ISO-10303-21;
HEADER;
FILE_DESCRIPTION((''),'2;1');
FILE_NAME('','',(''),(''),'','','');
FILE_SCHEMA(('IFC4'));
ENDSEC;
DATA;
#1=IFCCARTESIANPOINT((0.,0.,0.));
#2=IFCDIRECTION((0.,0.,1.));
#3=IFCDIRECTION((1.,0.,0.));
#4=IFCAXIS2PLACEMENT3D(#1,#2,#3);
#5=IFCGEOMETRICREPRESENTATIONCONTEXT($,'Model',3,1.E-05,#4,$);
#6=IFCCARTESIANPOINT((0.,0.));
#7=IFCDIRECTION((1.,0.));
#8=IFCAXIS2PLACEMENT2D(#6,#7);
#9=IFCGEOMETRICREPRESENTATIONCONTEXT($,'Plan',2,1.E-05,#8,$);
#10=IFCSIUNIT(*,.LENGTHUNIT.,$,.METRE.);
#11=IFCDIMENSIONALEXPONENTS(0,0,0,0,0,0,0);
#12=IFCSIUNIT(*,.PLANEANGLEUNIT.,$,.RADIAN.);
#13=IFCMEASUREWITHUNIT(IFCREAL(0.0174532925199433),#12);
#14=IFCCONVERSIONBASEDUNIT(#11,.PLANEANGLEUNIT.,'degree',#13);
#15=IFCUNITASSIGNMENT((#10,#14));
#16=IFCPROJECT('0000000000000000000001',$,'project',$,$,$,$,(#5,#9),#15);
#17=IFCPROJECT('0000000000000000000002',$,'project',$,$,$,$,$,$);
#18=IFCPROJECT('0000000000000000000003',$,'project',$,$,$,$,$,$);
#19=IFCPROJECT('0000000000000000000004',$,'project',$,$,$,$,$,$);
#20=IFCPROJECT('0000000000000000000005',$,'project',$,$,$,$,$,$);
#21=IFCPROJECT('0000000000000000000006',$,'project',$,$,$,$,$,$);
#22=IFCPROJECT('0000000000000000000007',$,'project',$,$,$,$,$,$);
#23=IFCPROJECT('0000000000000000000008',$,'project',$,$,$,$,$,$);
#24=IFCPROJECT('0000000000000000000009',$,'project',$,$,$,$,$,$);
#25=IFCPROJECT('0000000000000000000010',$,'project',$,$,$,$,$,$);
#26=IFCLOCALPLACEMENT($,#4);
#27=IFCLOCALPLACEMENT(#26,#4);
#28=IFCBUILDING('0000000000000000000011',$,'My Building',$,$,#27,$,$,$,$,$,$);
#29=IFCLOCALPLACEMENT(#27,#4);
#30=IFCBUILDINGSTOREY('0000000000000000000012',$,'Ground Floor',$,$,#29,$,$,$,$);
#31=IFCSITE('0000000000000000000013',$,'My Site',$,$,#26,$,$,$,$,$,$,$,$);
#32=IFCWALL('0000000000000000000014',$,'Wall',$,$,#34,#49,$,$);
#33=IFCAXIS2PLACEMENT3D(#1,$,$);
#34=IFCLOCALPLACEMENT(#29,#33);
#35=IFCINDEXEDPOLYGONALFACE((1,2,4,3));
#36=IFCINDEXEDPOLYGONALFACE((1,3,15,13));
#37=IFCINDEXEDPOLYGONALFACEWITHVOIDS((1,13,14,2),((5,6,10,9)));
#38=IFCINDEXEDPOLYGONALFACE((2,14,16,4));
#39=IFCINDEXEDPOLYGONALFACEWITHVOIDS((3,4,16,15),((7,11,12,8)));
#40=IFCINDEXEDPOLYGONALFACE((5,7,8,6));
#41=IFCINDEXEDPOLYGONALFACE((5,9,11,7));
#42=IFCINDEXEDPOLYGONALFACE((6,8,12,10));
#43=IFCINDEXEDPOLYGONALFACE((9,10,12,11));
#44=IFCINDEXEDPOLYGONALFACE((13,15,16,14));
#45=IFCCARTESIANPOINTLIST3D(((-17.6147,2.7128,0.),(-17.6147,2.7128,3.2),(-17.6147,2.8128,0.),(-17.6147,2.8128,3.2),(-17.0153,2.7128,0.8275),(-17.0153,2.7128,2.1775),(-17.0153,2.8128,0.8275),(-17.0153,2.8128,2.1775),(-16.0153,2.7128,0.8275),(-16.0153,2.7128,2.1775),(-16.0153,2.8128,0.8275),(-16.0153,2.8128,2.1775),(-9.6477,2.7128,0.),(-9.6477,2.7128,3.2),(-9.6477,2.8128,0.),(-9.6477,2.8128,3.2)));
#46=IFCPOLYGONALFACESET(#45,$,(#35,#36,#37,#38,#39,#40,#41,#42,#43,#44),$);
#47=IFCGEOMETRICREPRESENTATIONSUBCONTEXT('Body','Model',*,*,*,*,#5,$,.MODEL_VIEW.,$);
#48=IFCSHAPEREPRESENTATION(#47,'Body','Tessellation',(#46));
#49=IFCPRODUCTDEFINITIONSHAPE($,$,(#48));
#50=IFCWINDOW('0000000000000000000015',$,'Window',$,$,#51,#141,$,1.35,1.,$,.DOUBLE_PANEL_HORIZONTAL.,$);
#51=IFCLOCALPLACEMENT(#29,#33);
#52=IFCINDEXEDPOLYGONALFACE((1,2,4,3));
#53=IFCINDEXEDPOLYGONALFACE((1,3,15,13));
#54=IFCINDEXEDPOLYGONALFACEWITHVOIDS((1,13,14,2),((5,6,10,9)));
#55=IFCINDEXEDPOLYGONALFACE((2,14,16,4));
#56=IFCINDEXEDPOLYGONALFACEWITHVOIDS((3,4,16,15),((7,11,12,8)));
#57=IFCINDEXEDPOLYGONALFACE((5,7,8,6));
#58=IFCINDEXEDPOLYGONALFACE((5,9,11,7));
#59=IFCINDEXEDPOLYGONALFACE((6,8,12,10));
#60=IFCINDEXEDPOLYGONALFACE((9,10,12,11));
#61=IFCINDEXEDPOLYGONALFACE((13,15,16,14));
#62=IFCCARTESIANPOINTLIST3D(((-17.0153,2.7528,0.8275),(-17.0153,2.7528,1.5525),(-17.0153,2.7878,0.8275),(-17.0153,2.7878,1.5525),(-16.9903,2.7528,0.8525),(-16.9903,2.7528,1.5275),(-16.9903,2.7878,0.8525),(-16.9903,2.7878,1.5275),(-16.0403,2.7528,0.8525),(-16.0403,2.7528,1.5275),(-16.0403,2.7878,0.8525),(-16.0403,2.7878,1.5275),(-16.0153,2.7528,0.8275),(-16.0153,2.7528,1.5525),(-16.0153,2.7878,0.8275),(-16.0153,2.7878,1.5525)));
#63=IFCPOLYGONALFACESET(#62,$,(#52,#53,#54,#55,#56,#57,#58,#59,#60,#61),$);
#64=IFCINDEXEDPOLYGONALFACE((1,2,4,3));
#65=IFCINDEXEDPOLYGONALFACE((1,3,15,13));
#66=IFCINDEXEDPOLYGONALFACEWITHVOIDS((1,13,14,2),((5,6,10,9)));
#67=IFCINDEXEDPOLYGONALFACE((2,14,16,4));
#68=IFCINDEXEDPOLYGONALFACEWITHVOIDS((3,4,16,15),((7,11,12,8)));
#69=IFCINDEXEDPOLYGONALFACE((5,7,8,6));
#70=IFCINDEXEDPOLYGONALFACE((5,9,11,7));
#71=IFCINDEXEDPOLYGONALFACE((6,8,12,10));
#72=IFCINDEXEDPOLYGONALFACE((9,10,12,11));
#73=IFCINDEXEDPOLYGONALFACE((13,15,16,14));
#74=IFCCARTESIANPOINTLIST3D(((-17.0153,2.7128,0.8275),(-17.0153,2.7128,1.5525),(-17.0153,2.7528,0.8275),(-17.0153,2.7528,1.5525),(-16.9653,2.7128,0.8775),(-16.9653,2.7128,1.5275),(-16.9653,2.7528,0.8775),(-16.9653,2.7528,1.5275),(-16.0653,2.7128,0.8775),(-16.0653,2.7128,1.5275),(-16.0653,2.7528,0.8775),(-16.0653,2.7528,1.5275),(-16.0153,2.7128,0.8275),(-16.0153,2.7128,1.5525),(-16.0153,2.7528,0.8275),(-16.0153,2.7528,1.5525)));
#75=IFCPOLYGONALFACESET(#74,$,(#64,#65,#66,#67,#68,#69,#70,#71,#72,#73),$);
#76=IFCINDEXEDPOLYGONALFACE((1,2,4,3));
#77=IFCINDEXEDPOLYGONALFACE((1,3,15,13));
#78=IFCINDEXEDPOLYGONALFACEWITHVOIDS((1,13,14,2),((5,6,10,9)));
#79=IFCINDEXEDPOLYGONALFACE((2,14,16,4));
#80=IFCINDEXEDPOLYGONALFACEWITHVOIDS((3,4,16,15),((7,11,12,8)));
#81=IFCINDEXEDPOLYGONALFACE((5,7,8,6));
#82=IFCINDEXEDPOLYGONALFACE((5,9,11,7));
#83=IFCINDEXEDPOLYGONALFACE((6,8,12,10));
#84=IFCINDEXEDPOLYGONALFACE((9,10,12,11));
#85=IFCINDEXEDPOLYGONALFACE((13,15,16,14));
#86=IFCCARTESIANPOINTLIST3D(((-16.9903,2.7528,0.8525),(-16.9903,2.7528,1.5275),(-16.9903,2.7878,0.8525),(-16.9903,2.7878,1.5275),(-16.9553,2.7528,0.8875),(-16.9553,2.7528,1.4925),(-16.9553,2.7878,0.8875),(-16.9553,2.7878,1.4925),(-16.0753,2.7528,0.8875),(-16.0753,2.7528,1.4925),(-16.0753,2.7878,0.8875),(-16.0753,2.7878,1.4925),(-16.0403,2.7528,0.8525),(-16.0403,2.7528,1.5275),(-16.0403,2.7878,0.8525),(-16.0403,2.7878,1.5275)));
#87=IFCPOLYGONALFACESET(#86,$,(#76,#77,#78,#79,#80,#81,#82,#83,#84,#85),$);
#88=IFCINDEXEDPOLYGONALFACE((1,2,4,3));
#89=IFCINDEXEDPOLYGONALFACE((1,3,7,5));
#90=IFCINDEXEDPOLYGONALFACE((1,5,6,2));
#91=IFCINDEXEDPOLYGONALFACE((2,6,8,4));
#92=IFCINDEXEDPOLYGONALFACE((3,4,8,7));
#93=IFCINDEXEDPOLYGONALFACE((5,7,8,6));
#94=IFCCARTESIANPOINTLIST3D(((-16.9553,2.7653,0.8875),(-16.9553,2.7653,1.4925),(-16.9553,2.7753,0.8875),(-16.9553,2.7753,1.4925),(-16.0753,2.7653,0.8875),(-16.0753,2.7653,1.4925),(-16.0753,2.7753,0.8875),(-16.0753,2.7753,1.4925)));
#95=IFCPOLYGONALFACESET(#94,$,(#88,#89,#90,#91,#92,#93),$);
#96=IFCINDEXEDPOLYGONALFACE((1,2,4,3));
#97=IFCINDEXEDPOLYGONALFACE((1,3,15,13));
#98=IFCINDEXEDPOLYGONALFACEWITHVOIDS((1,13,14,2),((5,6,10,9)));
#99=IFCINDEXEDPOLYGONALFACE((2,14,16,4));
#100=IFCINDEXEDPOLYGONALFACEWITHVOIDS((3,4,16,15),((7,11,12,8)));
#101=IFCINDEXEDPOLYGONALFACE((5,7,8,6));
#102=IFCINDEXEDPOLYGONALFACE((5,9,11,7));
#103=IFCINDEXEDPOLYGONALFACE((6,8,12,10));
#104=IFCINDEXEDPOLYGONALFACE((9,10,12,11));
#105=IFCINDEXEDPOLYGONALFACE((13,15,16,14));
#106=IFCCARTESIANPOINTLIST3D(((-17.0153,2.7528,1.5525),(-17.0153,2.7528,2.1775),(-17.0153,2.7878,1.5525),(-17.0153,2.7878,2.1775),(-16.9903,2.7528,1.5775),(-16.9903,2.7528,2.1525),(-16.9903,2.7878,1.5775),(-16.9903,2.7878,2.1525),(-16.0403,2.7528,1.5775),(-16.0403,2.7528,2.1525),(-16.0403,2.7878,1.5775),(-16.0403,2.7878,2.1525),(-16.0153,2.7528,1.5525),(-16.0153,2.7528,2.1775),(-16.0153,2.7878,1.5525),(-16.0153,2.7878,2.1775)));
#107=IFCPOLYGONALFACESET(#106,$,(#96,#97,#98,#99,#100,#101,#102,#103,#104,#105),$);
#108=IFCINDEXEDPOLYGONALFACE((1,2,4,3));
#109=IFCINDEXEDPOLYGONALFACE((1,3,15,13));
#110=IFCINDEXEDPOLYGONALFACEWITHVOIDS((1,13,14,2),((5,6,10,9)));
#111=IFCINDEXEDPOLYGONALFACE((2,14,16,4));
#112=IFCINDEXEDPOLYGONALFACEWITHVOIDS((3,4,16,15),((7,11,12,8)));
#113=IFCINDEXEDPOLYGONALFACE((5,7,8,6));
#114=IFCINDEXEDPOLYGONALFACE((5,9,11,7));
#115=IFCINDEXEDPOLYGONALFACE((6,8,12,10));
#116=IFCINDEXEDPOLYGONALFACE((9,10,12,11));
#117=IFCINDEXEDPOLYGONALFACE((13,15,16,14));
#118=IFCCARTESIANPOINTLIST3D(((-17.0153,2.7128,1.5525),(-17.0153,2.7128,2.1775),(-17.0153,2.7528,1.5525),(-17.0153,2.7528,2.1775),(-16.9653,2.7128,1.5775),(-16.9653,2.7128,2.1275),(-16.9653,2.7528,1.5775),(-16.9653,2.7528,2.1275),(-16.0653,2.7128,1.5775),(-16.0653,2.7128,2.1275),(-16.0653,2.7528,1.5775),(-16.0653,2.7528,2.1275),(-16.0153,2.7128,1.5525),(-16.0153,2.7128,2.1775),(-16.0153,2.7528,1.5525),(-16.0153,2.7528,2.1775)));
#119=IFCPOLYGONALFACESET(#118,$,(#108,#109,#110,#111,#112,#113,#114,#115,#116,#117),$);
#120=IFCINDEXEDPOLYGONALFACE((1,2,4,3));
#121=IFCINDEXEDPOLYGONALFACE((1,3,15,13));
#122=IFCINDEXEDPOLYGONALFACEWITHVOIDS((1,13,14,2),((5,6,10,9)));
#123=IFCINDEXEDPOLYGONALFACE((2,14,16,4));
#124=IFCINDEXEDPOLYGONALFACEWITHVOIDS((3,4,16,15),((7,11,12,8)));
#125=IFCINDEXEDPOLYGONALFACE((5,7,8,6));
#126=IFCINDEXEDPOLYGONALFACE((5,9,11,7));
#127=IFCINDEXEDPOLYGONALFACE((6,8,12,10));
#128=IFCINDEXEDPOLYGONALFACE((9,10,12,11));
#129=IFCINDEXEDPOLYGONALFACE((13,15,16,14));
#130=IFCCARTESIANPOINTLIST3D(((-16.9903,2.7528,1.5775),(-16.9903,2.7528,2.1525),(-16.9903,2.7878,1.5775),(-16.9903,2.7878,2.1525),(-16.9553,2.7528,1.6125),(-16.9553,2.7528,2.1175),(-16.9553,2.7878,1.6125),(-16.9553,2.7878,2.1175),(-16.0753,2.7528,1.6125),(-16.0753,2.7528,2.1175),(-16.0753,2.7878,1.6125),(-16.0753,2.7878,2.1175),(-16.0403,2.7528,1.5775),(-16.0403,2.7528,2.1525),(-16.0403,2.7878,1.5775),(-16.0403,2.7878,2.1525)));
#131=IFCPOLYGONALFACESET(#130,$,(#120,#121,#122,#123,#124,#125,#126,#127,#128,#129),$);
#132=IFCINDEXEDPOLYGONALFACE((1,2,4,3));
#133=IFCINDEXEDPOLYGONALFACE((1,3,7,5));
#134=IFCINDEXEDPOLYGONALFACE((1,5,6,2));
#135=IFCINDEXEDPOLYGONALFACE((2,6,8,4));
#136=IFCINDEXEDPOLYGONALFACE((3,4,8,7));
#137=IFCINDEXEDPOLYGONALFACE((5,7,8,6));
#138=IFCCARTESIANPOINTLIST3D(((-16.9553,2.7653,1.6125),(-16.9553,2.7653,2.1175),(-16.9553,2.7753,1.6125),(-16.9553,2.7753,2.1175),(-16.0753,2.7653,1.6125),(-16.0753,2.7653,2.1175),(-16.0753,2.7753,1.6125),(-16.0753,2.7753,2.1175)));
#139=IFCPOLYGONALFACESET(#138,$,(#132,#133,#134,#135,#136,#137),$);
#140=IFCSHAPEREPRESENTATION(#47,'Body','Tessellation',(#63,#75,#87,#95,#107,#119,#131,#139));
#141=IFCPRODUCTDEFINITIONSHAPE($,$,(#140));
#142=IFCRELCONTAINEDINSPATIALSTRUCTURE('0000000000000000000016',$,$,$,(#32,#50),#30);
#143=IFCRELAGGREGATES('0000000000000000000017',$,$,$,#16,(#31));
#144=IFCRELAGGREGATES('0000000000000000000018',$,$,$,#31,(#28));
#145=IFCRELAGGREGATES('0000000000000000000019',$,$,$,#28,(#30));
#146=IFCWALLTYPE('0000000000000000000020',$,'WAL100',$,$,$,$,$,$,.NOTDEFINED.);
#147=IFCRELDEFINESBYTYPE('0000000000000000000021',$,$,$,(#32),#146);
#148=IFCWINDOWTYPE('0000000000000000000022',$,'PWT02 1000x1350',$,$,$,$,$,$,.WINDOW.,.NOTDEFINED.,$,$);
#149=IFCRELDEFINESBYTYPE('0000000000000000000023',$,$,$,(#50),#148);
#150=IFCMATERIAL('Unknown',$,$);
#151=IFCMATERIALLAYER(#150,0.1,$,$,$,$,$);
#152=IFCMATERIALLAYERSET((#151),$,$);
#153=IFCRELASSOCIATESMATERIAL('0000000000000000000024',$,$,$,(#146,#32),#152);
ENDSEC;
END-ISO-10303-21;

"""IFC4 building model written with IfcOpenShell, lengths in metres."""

from ifc_helpers import new_model, entity, si_unit, converted_unit, frame, origin_with_axes, origin_2d_with_axis, place, context, subcontext, project, spatial, line, indexed_curve, outline, extrude, shape, source, transform, mapped, material, layer, layer_set, layer_usage, type_object, type_shapes, element, fill, save


model = new_model("IFC4")

# Units and contexts
model_context = context("Model", 3, precision=1e-05, world=origin_with_axes())
plan_context = context("Plan", 2, precision=1e-05, world=origin_2d_with_axis())
body_context_1 = subcontext(model_context, "Body", "Model", "MODEL_VIEW")
body_context_2 = subcontext(plan_context, "Body", "Plan", "PLAN_VIEW")
ifc_project_1 = project(units=[si_unit("LENGTHUNIT", "METRE"), converted_unit("PLANEANGLEUNIT", "degree", entity("IfcReal", 0.0174532925199433), si_unit("PLANEANGLEUNIT", "RADIAN"), dimensions=[0, 0, 0, 0, 0, 0, 0])], contexts=[model_context, plan_context])
ifc_project_2 = project()
ifc_project_3 = project()
ifc_project_4 = project()
ifc_project_5 = project()
ifc_project_6 = project()
ifc_project_7 = project()
ifc_project_8 = project()
ifc_project_9 = project()
ifc_project_10 = project()

# Site, building, storey
site_placement = place(None, origin_with_axes())
site = spatial("IfcSite", under=ifc_project_1, at=site_placement, Name="My Site")
building_placement = place(site_placement, origin_with_axes())
building = spatial("IfcBuilding", under=site, at=building_placement, Name="My Building")
storey_placement = place(building_placement, origin_with_axes())
storey = spatial("IfcBuildingStorey", under=building, at=storey_placement, Name="Ground Floor")

# Shared definitions
ifc_material = material(Name="Unknown")

# Shared definitions
ifc_layer_1 = layer(ifc_material, 0.1)
ifc_layer_set_1 = layer_set([ifc_layer_1])
wall_type = type_object("IfcWallType", Name="WAL100", PredefinedType="NOTDEFINED", material=ifc_layer_set_1)

# Wall, opening, window
ifc_layer_usage_1 = layer_usage(ifc_layer_set_1, "AXIS2", "POSITIVE", 0.0)
wall_1_placement = place(storey_placement, frame((-17.6147, 2.7128, 0.0), z_axis=(0.0, 0.0, 1.0), x_axis=(1.0, 0.0, 0.0)))
wall_1 = element("IfcWall", 1, at=wall_1_placement, inside=storey, type_object=wall_type, material=ifc_layer_usage_1, Name="Wall", context=body_context_1, shape_type="SweptSolid", body=[
    extrude(outline(indexed_curve([(0.0, 0.0), (0.0, 0.1), (7.967, 0.1), (7.967, 0.0), (0.0, 0.0)], self_intersect=False)), origin_with_axes(), (0.0, 0.0, 1.0), 3.2),
])
shared_shape_1 = source(origin_with_axes(), body_context_1, "Body", "SweptSolid", [
    extrude(outline(indexed_curve([(0.0, 0.0), (1.0, 0.0), (1.0, 1.35), (0.0, 1.35)], segments=[line(1, 2, 2, 3, 3, 4, 4, 1)])), frame((0.0, -0.1, 0.0), z_axis=(0.0, -1.0, 0.0), x_axis=(1.0, 0.0, 0.0)), (0.0, 0.0, -1.0), 0.3),
])
opening_1_placement = place(wall_1_placement, frame((0.5995, 0.0, 0.8275), z_axis=(0.0, 0.0, 1.0), x_axis=(1.0, 0.0, 0.0)))
opening_1 = element("IfcOpeningElement", 2, at=opening_1_placement, cuts=wall_1, PredefinedType="OPENING", context=body_context_1, shape_type="MappedRepresentation", body=[
    mapped(shared_shape_1, transform((0.0, 0.0, 0.0), x_axis=(1.0, 0.0, 0.0), y_axis=(0.0, 1.0, 0.0), z_axis=(0.0, 0.0, 1.0), scale=1.0)),
])
window_type_1 = type_object("IfcWindowType", Name="PWT02 1000x1350", PartitioningType="NOTDEFINED", PredefinedType="WINDOW")
shared_shape_2 = source(origin_with_axes(), body_context_1, "Body", "SweptSolid", [
    extrude(outline(indexed_curve([(0.0, 0.0), (1.0, 0.0), (1.0, 0.725), (0.0, 0.725)], segments=[line(1, 2, 2, 3, 3, 4, 4, 1)]), holes=[indexed_curve([(0.025, 0.025), (0.975, 0.025), (0.975, 0.7), (0.025, 0.7)], segments=[line(1, 2, 2, 3, 3, 4, 4, 1)])]), frame((0.0, 0.04, 0.0), z_axis=(0.0, -1.0, 0.0), x_axis=(1.0, 0.0, 0.0)), (0.0, 0.0, -1.0), 0.035),
    extrude(outline(indexed_curve([(0.0, 0.0), (1.0, 0.0), (1.0, 0.725), (0.0, 0.725)], segments=[line(1, 2, 2, 3, 3, 4, 4, 1)]), holes=[indexed_curve([(0.05, 0.05), (0.95, 0.05), (0.95, 0.7), (0.05, 0.7)], segments=[line(1, 2, 2, 3, 3, 4, 4, 1)])]), frame((0.0, 0.0, 0.0), z_axis=(0.0, -1.0, 0.0), x_axis=(1.0, 0.0, 0.0)), (0.0, 0.0, -1.0), 0.04),
    extrude(outline(indexed_curve([(0.0, 0.0), (0.95, 0.0), (0.95, 0.675), (0.0, 0.675)], segments=[line(1, 2, 2, 3, 3, 4, 4, 1)]), holes=[indexed_curve([(0.035, 0.035), (0.915, 0.035), (0.915, 0.64), (0.035, 0.64)], segments=[line(1, 2, 2, 3, 3, 4, 4, 1)])]), frame((0.025, 0.04, 0.025), z_axis=(0.0, -1.0, 0.0), x_axis=(1.0, 0.0, 0.0)), (0.0, 0.0, -1.0), 0.035),
    extrude(outline(indexed_curve([(0.035, 0.035), (0.915, 0.035), (0.915, 0.64), (0.035, 0.64)], segments=[line(1, 2, 2, 3, 3, 4, 4, 1)])), frame((0.025, 0.0525, 0.025), z_axis=(0.0, -1.0, 0.0), x_axis=(1.0, 0.0, 0.0)), (0.0, 0.0, -1.0), 0.01),
    extrude(outline(indexed_curve([(0.0, 0.0), (1.0, 0.0), (1.0, 0.625), (0.0, 0.625)], segments=[line(1, 2, 2, 3, 3, 4, 4, 1)]), holes=[indexed_curve([(0.025, 0.025), (0.975, 0.025), (0.975, 0.6), (0.025, 0.6)], segments=[line(1, 2, 2, 3, 3, 4, 4, 1)])]), frame((0.0, 0.04, 0.725), z_axis=(0.0, -1.0, 0.0), x_axis=(1.0, 0.0, 0.0)), (0.0, 0.0, -1.0), 0.035),
    extrude(outline(indexed_curve([(0.0, 0.0), (1.0, 0.0), (1.0, 0.625), (0.0, 0.625)], segments=[line(1, 2, 2, 3, 3, 4, 4, 1)]), holes=[indexed_curve([(0.05, 0.025), (0.95, 0.025), (0.95, 0.575), (0.05, 0.575)], segments=[line(1, 2, 2, 3, 3, 4, 4, 1)])]), frame((0.0, 0.0, 0.725), z_axis=(0.0, -1.0, 0.0), x_axis=(1.0, 0.0, 0.0)), (0.0, 0.0, -1.0), 0.04),
    extrude(outline(indexed_curve([(0.0, 0.0), (0.95, 0.0), (0.95, 0.575), (0.0, 0.575)], segments=[line(1, 2, 2, 3, 3, 4, 4, 1)]), holes=[indexed_curve([(0.035, 0.035), (0.915, 0.035), (0.915, 0.54), (0.035, 0.54)], segments=[line(1, 2, 2, 3, 3, 4, 4, 1)])]), frame((0.025, 0.04, 0.75), z_axis=(0.0, -1.0, 0.0), x_axis=(1.0, 0.0, 0.0)), (0.0, 0.0, -1.0), 0.035),
    extrude(outline(indexed_curve([(0.035, 0.035), (0.915, 0.035), (0.915, 0.54), (0.035, 0.54)], segments=[line(1, 2, 2, 3, 3, 4, 4, 1)])), frame((0.025, 0.0525, 0.75), z_axis=(0.0, -1.0, 0.0), x_axis=(1.0, 0.0, 0.0)), (0.0, 0.0, -1.0), 0.01),
])
shared_shape_3 = source(origin_with_axes(), body_context_2, "Body", "Curve2D", [
    entity("IfcIndexedPolyCurve", entity("IfcCartesianPointList2D", [[0.05, 0.0], [0.95, 0.0]]), [entity("IfcLineIndex", [1, 2])]),
    entity("IfcIndexedPolyCurve", entity("IfcCartesianPointList2D", [[0.0, 0.075], [0.025, 0.075], [0.025, 0.04], [0.05, 0.04], [0.05, 0.0], [0.0, 0.0]]), [entity("IfcLineIndex", [1, 2, 2, 3, 3, 4, 4, 5, 5, 6, 6, 1])]),
    entity("IfcIndexedPolyCurve", entity("IfcCartesianPointList2D", [[1.0, 0.075], [0.975, 0.075], [0.975, 0.04], [0.95, 0.04], [0.95, 0.0], [1.0, 0.0]]), [entity("IfcLineIndex", [1, 2, 2, 3, 3, 4, 4, 5, 5, 6, 6, 1])]),
    entity("IfcIndexedPolyCurve", entity("IfcCartesianPointList2D", [[0.025, 0.04], [0.06, 0.04], [0.06, 0.075], [0.025, 0.075]]), [entity("IfcLineIndex", [1, 2, 2, 3, 3, 4, 4, 1])]),
    entity("IfcIndexedPolyCurve", entity("IfcCartesianPointList2D", [[0.975, 0.04], [0.94, 0.04], [0.94, 0.075], [0.975, 0.075]]), [entity("IfcLineIndex", [1, 2, 2, 3, 3, 4, 4, 1])]),
    entity("IfcIndexedPolyCurve", entity("IfcCartesianPointList2D", [[0.06, 0.04], [0.94, 0.04]]), [entity("IfcLineIndex", [1, 2])]),
    entity("IfcIndexedPolyCurve", entity("IfcCartesianPointList2D", [[0.06, 0.075], [0.94, 0.075]]), [entity("IfcLineIndex", [1, 2])]),
    entity("IfcIndexedPolyCurve", entity("IfcCartesianPointList2D", [[0.06, 0.0575], [0.94, 0.0575]]), [entity("IfcLineIndex", [1, 2])]),
])
type_shapes(window_type_1, [shared_shape_2, shared_shape_3])
window_1_placement = place(opening_1_placement, origin_with_axes())
window_1 = element("IfcWindow", 3, at=window_1_placement, inside=storey, type_object=window_type_1, Name="Window", OverallHeight=1.35, OverallWidth=1.0, PartitioningType="DOUBLE_PANEL_HORIZONTAL", shapes=[
    shape(body_context_1, "Body", "MappedRepresentation", [mapped(shared_shape_2, transform((0.0, 0.0, 0.0), x_axis=(1.0, 0.0, 0.0), y_axis=(0.0, 1.0, 0.0), z_axis=(0.0, 0.0, 1.0), scale=1.0))]),
    shape(body_context_2, "Body", "MappedRepresentation", [mapped(shared_shape_3, transform((0.0, 0.0, 0.0), x_axis=(1.0, 0.0, 0.0), y_axis=(0.0, 1.0, 0.0), z_axis=(0.0, 0.0, 1.0), scale=1.0))]),
])
fill(opening_1, window_1)

save(model, "model.ifc")
